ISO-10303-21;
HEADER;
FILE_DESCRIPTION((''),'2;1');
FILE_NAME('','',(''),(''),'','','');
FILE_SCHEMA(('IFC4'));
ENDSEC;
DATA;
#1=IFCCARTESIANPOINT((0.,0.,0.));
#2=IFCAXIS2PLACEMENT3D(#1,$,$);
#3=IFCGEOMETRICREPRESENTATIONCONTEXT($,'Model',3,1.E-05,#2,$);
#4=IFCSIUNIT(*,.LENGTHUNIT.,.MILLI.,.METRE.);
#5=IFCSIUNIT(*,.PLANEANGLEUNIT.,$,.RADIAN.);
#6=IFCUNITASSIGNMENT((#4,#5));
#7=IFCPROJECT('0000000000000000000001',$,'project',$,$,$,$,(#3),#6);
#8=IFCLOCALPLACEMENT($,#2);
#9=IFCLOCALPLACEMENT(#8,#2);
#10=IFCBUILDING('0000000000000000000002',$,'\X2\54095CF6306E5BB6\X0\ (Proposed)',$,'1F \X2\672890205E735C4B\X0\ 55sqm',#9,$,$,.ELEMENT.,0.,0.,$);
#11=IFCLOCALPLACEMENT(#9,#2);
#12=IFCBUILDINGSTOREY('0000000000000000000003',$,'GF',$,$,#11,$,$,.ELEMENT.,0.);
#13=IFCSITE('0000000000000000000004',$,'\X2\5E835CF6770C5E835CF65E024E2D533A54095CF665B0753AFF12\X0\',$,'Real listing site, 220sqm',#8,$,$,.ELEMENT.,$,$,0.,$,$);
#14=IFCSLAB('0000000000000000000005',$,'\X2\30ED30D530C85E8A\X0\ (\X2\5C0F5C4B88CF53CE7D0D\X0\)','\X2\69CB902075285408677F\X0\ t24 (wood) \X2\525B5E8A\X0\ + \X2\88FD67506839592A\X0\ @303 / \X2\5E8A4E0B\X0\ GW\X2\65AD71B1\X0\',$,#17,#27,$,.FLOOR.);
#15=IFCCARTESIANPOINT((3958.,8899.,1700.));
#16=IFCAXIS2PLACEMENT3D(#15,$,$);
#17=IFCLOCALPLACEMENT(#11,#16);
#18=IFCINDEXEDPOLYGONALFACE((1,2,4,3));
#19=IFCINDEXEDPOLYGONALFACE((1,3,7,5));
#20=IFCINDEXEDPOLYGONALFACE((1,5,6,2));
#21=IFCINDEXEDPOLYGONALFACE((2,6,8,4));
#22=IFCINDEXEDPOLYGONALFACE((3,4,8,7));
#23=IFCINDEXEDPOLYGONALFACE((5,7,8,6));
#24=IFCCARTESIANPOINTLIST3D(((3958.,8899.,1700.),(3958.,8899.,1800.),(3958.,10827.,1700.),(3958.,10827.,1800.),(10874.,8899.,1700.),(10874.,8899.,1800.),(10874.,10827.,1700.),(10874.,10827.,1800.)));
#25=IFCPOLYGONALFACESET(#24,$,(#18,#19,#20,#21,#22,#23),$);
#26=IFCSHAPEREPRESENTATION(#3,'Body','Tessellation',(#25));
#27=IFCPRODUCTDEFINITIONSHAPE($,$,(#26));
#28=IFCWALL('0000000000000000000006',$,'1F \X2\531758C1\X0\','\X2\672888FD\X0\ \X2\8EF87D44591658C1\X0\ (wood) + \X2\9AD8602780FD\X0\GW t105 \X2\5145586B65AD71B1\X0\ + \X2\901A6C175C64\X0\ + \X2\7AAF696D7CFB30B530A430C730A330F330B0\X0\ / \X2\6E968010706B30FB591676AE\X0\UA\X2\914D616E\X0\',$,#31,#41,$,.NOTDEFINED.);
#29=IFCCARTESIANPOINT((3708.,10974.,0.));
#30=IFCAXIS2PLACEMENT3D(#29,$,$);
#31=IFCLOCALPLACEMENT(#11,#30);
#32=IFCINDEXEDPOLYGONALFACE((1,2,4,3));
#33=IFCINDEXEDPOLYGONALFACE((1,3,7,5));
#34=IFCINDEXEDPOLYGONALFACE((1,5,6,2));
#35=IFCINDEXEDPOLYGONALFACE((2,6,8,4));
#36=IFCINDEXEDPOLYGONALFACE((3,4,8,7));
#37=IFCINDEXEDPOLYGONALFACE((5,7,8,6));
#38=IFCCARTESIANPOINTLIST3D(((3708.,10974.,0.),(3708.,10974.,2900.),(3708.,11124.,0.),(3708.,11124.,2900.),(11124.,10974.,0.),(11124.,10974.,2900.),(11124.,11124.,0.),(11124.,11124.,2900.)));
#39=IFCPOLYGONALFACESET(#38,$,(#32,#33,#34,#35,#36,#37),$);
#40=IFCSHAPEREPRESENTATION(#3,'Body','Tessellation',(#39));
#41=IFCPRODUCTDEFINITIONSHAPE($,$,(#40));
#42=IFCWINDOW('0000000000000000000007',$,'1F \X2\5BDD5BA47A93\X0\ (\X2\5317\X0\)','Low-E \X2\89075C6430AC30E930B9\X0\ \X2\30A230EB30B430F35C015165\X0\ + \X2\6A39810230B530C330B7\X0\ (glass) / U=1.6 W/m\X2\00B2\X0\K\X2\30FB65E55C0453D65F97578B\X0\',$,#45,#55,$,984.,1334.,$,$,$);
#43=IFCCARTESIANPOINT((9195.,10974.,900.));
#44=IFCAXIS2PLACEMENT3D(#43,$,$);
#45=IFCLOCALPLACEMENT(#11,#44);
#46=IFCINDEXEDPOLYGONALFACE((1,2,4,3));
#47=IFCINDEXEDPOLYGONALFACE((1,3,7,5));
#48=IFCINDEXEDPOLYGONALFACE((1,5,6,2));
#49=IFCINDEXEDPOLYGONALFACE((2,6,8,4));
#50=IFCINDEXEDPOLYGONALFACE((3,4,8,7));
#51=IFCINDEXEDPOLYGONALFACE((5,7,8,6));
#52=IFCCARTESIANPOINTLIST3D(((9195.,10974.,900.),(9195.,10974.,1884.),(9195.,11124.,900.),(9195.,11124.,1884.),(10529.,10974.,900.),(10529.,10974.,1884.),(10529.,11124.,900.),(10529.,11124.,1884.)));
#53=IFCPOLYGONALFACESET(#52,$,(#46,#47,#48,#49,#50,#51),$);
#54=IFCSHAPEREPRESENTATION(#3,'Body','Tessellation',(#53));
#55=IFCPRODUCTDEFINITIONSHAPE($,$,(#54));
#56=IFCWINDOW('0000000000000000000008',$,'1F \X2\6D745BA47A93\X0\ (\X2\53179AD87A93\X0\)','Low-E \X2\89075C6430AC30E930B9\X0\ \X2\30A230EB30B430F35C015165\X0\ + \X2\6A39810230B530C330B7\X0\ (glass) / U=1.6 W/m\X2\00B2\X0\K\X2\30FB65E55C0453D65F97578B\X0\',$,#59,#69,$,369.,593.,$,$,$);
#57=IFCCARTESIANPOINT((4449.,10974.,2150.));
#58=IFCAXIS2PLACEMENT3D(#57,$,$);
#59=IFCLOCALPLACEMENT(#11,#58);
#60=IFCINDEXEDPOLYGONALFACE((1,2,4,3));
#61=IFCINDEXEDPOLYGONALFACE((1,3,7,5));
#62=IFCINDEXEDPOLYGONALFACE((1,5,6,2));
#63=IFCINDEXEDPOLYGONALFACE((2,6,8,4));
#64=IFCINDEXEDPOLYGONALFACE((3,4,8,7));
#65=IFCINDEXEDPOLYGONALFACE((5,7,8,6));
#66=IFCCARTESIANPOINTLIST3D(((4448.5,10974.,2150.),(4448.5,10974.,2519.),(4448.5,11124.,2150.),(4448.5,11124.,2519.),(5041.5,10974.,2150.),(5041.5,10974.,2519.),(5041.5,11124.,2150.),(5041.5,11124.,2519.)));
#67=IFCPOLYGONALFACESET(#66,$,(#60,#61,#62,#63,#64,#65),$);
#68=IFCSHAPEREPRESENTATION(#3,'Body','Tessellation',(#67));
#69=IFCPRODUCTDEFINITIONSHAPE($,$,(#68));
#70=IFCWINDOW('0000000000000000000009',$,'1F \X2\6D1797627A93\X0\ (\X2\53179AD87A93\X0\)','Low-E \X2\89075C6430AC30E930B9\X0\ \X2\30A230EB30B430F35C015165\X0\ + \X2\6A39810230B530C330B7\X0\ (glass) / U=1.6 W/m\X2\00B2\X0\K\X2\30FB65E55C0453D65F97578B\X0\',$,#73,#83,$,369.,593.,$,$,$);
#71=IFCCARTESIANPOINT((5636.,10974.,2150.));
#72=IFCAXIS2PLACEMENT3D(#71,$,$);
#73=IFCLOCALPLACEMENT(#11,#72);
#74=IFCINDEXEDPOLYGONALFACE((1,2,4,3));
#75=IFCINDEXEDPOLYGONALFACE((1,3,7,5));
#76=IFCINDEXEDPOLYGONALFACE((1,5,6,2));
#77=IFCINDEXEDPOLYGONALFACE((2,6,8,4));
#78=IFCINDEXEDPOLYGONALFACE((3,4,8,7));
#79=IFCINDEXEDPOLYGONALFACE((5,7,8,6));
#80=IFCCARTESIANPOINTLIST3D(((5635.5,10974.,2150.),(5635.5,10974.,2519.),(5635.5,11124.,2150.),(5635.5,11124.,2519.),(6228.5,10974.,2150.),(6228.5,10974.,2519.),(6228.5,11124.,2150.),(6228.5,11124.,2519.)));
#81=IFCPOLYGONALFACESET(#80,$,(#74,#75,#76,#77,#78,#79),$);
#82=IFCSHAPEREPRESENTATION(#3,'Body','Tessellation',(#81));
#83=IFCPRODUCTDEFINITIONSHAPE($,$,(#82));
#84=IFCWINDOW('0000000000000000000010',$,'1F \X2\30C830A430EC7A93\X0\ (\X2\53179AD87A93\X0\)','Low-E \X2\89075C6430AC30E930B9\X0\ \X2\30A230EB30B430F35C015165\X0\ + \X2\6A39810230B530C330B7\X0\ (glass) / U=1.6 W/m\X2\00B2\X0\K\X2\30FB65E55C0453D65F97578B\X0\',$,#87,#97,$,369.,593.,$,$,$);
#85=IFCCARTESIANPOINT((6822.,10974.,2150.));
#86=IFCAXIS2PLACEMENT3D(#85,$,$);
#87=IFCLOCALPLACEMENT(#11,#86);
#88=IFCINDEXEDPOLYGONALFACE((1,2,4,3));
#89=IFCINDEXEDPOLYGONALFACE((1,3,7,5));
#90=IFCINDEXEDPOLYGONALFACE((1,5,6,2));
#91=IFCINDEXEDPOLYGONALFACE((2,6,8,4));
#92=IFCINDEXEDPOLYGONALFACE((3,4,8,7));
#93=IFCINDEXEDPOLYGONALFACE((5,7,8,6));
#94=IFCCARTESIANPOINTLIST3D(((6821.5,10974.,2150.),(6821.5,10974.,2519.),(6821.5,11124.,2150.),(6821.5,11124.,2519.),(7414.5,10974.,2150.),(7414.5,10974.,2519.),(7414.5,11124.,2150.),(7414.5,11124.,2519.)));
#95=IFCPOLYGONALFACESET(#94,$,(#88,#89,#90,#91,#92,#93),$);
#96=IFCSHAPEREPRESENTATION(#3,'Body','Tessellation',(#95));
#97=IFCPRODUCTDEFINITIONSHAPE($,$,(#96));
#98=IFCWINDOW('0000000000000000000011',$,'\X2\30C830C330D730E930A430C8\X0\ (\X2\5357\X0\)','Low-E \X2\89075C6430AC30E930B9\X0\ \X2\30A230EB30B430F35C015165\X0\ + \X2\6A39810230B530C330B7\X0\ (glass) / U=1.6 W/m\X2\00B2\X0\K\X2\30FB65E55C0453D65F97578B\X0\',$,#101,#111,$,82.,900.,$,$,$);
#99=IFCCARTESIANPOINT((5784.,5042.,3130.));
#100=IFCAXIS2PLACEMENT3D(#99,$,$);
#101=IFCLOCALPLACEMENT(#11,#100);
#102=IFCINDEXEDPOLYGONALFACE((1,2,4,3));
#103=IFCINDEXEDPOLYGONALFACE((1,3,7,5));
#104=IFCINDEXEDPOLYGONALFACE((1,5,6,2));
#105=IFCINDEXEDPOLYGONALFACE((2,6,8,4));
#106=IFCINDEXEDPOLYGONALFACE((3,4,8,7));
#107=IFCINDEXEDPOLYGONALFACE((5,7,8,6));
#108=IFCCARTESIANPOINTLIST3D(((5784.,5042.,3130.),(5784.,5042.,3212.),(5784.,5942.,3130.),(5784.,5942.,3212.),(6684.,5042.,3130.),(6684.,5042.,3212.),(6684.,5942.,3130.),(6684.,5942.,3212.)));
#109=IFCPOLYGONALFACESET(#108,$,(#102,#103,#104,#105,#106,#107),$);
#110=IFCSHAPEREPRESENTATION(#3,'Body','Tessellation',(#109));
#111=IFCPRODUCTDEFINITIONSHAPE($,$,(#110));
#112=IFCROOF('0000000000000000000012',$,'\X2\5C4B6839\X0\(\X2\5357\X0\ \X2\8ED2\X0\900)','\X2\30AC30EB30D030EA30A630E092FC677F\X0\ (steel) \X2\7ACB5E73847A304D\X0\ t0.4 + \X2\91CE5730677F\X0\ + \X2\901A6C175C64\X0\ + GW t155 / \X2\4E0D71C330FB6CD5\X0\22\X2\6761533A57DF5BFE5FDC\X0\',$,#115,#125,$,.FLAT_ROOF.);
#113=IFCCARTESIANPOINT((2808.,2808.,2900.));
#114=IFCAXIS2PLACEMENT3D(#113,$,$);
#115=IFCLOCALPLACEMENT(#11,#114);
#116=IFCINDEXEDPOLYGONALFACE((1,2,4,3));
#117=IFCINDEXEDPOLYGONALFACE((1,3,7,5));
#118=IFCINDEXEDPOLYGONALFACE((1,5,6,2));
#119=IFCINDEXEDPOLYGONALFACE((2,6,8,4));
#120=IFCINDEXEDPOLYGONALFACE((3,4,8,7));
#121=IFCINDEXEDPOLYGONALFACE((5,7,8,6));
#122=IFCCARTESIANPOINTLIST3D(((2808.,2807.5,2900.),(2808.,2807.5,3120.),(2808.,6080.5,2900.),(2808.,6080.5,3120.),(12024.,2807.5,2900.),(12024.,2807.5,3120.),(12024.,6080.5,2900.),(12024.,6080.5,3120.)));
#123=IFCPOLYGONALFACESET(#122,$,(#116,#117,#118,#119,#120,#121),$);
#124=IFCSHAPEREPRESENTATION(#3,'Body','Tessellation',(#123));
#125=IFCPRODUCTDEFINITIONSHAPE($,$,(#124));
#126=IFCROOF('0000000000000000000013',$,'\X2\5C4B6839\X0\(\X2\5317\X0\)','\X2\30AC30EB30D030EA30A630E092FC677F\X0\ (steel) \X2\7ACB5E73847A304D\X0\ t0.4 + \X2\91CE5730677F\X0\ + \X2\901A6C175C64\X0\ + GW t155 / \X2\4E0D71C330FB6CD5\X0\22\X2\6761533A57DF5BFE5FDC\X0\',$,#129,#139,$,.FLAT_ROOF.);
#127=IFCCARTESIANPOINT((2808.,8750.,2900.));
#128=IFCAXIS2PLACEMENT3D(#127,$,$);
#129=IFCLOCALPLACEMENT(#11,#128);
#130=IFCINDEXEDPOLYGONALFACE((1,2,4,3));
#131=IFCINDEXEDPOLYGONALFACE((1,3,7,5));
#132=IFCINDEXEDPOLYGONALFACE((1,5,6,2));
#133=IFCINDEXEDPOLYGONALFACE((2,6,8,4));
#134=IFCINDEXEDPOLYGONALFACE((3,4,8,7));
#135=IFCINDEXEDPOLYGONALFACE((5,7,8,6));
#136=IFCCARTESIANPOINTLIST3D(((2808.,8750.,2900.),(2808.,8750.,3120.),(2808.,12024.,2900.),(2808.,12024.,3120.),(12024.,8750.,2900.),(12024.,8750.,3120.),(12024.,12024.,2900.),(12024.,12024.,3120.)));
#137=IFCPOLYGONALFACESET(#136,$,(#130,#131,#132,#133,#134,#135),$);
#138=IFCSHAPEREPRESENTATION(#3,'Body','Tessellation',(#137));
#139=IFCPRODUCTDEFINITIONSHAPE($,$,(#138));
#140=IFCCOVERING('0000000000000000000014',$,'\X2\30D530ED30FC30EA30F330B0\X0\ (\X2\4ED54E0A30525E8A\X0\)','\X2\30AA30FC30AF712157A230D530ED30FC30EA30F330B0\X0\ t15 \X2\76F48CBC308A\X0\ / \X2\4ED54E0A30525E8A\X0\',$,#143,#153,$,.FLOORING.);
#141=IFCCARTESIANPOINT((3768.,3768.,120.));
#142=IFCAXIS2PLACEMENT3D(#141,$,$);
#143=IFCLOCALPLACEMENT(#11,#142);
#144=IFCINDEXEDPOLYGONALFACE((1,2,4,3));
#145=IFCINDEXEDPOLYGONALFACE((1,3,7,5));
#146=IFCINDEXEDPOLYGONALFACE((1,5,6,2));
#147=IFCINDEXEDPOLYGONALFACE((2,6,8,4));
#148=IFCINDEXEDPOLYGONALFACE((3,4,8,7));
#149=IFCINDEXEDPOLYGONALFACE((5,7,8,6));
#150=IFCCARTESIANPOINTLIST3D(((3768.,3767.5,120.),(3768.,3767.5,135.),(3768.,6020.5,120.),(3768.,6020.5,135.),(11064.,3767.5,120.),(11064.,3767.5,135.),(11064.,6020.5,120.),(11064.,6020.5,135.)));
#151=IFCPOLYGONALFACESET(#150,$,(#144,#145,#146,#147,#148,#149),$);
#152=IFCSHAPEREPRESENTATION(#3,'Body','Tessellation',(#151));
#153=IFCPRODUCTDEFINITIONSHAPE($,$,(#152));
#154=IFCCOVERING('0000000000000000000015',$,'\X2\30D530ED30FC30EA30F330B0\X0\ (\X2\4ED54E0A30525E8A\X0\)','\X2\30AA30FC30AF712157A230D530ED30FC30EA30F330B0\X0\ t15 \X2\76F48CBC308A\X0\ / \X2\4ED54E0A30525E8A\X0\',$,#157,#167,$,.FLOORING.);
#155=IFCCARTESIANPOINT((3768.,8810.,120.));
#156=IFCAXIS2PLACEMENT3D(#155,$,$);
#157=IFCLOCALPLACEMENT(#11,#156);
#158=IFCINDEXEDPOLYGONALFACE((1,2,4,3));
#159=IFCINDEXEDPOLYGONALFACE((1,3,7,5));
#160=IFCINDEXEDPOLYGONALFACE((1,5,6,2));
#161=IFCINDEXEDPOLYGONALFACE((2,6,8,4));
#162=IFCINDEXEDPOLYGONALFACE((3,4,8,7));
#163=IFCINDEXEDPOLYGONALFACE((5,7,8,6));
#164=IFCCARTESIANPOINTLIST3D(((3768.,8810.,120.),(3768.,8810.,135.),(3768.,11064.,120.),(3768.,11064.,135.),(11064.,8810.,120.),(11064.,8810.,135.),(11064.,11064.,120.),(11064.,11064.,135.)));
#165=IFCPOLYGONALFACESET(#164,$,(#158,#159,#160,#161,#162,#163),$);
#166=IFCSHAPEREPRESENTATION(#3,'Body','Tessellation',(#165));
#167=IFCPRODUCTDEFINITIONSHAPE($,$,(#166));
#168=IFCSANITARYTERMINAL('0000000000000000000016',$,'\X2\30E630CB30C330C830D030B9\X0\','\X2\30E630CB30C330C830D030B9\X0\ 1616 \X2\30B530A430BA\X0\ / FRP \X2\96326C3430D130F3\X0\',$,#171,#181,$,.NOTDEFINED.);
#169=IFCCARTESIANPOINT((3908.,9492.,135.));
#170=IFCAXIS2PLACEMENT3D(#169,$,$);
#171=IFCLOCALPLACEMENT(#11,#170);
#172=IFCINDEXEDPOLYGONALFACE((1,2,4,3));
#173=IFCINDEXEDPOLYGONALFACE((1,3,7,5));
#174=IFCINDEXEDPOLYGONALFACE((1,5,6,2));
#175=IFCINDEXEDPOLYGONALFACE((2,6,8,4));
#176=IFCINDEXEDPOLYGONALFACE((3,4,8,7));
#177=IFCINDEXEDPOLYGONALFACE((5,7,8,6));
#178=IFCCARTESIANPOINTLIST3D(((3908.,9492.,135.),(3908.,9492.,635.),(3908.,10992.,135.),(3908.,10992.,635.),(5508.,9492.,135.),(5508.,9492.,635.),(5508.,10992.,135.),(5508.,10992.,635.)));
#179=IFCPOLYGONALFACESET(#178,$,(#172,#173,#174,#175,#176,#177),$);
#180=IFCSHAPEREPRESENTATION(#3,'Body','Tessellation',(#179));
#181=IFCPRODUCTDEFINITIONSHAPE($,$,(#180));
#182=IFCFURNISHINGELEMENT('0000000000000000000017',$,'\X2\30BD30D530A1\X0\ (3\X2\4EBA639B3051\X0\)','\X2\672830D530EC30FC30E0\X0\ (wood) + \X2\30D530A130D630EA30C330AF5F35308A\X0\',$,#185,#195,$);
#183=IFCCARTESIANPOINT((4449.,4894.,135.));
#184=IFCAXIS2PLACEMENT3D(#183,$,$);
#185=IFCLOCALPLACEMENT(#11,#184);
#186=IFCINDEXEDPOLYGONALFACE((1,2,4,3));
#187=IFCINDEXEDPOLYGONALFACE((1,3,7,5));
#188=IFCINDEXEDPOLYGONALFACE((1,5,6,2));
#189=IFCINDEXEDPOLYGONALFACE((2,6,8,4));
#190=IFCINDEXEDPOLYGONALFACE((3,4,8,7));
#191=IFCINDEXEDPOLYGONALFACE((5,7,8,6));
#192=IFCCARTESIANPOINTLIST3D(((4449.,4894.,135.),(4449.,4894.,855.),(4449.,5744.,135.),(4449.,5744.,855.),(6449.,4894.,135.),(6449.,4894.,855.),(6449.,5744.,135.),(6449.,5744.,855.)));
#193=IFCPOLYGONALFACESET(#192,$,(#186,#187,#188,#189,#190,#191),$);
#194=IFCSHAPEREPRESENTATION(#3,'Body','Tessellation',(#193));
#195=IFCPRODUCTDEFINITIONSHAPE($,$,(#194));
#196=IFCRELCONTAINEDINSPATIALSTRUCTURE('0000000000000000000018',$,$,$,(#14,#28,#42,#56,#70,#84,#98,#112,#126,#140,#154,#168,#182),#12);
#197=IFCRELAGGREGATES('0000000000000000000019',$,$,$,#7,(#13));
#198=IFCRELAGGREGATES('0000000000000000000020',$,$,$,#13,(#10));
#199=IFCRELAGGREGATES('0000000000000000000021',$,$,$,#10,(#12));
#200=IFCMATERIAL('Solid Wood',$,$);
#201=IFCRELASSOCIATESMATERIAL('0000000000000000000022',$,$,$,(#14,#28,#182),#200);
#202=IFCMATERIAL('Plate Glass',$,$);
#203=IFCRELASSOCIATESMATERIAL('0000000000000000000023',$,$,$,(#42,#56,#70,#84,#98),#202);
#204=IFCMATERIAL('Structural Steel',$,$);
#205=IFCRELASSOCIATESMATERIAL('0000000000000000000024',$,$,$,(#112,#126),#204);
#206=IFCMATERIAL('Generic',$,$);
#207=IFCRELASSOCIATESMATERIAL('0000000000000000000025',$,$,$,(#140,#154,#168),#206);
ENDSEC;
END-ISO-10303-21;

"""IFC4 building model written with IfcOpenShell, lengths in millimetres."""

from ifc_helpers import new_model, si_unit, frame, frame_2d, origin, place, context, project, spatial, rectangle, extrude, material, element, fill, save


model = new_model("IFC4")

# Units and contexts
model_context = context("Model", 3, precision=1e-05, world=origin())
ifc_project = project(units=[si_unit("LENGTHUNIT", "METRE", prefix="MILLI"), si_unit("PLANEANGLEUNIT", "RADIAN")], contexts=[model_context])

# Site, building, storey
site_placement = place(None, origin())
site = spatial("IfcSite", under=ifc_project, at=site_placement, Name="広島県広島市中区吉島新町２", ObjectType="Real listing site, 220sqm", CompositionType="ELEMENT", RefElevation=0.0)
building_placement = place(site_placement, origin())
building = spatial("IfcBuilding", under=site, at=building_placement, Name="吉島の家 (Proposed)", ObjectType="1F 木造平屋 55sqm", CompositionType="ELEMENT", ElevationOfRefHeight=0.0, ElevationOfTerrain=0.0)
storey_placement = place(building_placement, origin())
storey = spatial("IfcBuildingStorey", under=building, at=storey_placement, Name="GF", CompositionType="ELEMENT", Elevation=0.0)

# Slab
ifc_material_1 = material(Name="Solid Wood")
slab_1_placement = place(storey_placement, frame((3958.0, 8899.0, 1700.0)))
element("IfcSlab", 1, at=slab_1_placement, inside=storey, material=ifc_material_1, Name="ロフト床 (小屋裏収納)", Description="構造用合板 t24 (wood) 剛床 + 製材根太 @303 / 床下 GW断熱", PredefinedType="FLOOR", context=model_context, shape_type="SweptSolid", body=[
    extrude(rectangle(XDim=6916.0, YDim=1928.0, at=frame_2d((3458.0, 964.0))), frame((3958.0, 8899.0, 1700.0)), (0.0, 0.0, 1.0), 100.0),
])

# Shared definitions
ifc_material_2 = material(Name="Plate Glass")

# Wall, openings, windows
wall_1_placement = place(storey_placement, frame((3708.0, 10974.0, 0.0)))
wall_1 = element("IfcWall", 2, at=wall_1_placement, inside=storey, material=ifc_material_1, Name="1F 北壁", Description="木製 軸組外壁 (wood) + 高性能GW t105 充填断熱 + 通気層 + 窯業系サイディング / 準耐火・外皮UA配慮", PredefinedType="NOTDEFINED", context=model_context, shape_type="SweptSolid", body=[
    extrude(rectangle(XDim=7416.0, YDim=150.0, at=frame_2d((3708.0, 75.0))), frame((3708.0, 10974.0, 0.0)), (0.0, 0.0, 1.0), 2900.0),
])
opening_1_placement = place(storey_placement, frame((9195.0, 10974.0, 900.0)))
opening_1 = element("IfcOpeningElement", 3, at=opening_1_placement, cuts=wall_1, PredefinedType="NOTDEFINED", context=model_context, shape_type="SweptSolid", body=[
    extrude(rectangle(XDim=1334.0, YDim=150.0, at=frame_2d((667.0, 75.0))), frame((9195.0, 10974.0, 900.0)), (0.0, 0.0, 1.0), 984.0),
])
opening_2_placement = place(storey_placement, frame((4449.0, 10974.0, 2150.0)))
opening_2 = element("IfcOpeningElement", 4, at=opening_2_placement, cuts=wall_1, PredefinedType="NOTDEFINED", context=model_context, shape_type="SweptSolid", body=[
    extrude(rectangle(XDim=593.0, YDim=150.0, at=frame_2d((296.0, 75.0))), frame((4449.0, 10974.0, 2150.0)), (0.0, 0.0, 1.0), 369.0),
])
opening_3_placement = place(storey_placement, frame((5636.0, 10974.0, 2150.0)))
opening_3 = element("IfcOpeningElement", 5, at=opening_3_placement, cuts=wall_1, PredefinedType="NOTDEFINED", context=model_context, shape_type="SweptSolid", body=[
    extrude(rectangle(XDim=593.0, YDim=150.0, at=frame_2d((296.0, 75.0))), frame((5636.0, 10974.0, 2150.0)), (0.0, 0.0, 1.0), 369.0),
])
opening_4_placement = place(storey_placement, frame((6822.0, 10974.0, 2150.0)))
opening_4 = element("IfcOpeningElement", 6, at=opening_4_placement, cuts=wall_1, PredefinedType="NOTDEFINED", context=model_context, shape_type="SweptSolid", body=[
    extrude(rectangle(XDim=593.0, YDim=150.0, at=frame_2d((296.0, 75.0))), frame((6822.0, 10974.0, 2150.0)), (0.0, 0.0, 1.0), 369.0),
])
window_1_placement = place(storey_placement, frame((9195.0, 10974.0, 900.0)))
window_1 = element("IfcWindow", 7, at=window_1_placement, inside=storey, material=ifc_material_2, Name="1F 寝室窓 (北)", Description="Low-E 複層ガラス アルゴン封入 + 樹脂サッシ (glass) / U=1.6 W/m²K・日射取得型", OverallHeight=984.0, OverallWidth=1334.0, context=model_context, shape_type="SweptSolid", body=[
    extrude(rectangle(XDim=1334.0, YDim=150.0, at=frame_2d((667.0, 75.0))), frame((9195.0, 10974.0, 900.0)), (0.0, 0.0, 1.0), 984.0),
])
fill(opening_1, window_1)
window_2_placement = place(storey_placement, frame((4449.0, 10974.0, 2150.0)))
window_2 = element("IfcWindow", 8, at=window_2_placement, inside=storey, material=ifc_material_2, Name="1F 浴室窓 (北高窓)", Description="Low-E 複層ガラス アルゴン封入 + 樹脂サッシ (glass) / U=1.6 W/m²K・日射取得型", OverallHeight=369.0, OverallWidth=593.0, context=model_context, shape_type="SweptSolid", body=[
    extrude(rectangle(XDim=593.0, YDim=150.0, at=frame_2d((296.0, 75.0))), frame((4449.0, 10974.0, 2150.0)), (0.0, 0.0, 1.0), 369.0),
])
fill(opening_2, window_2)
window_3_placement = place(storey_placement, frame((5636.0, 10974.0, 2150.0)))
window_3 = element("IfcWindow", 9, at=window_3_placement, inside=storey, material=ifc_material_2, Name="1F 洗面窓 (北高窓)", Description="Low-E 複層ガラス アルゴン封入 + 樹脂サッシ (glass) / U=1.6 W/m²K・日射取得型", OverallHeight=369.0, OverallWidth=593.0, context=model_context, shape_type="SweptSolid", body=[
    extrude(rectangle(XDim=593.0, YDim=150.0, at=frame_2d((296.0, 75.0))), frame((5636.0, 10974.0, 2150.0)), (0.0, 0.0, 1.0), 369.0),
])
fill(opening_3, window_3)
window_4_placement = place(storey_placement, frame((6822.0, 10974.0, 2150.0)))
window_4 = element("IfcWindow", 10, at=window_4_placement, inside=storey, material=ifc_material_2, Name="1F トイレ窓 (北高窓)", Description="Low-E 複層ガラス アルゴン封入 + 樹脂サッシ (glass) / U=1.6 W/m²K・日射取得型", OverallHeight=369.0, OverallWidth=593.0, context=model_context, shape_type="SweptSolid", body=[
    extrude(rectangle(XDim=593.0, YDim=150.0, at=frame_2d((296.0, 75.0))), frame((6822.0, 10974.0, 2150.0)), (0.0, 0.0, 1.0), 369.0),
])
fill(opening_4, window_4)

# Window
window_5_placement = place(storey_placement, frame((5784.0, 5042.0, 3130.0)))
element("IfcWindow", 11, at=window_5_placement, inside=storey, material=ifc_material_2, Name="トップライト (南)", Description="Low-E 複層ガラス アルゴン封入 + 樹脂サッシ (glass) / U=1.6 W/m²K・日射取得型", OverallHeight=82.0, OverallWidth=900.0, context=model_context, shape_type="SweptSolid", body=[
    extrude(rectangle(XDim=900.0, YDim=900.0, at=frame_2d((450.0, 450.0))), frame((5784.0, 5042.0, 3130.0)), (0.0, 0.0, 1.0), 82.0),
])

# Roofs
ifc_material_3 = material(Name="Structural Steel")
roof_1_placement = place(storey_placement, frame((2808.0, 2808.0, 2900.0)))
element("IfcRoof", 12, at=roof_1_placement, inside=storey, material=ifc_material_3, Name="屋根(南 軒900)", Description="ガルバリウム鋼板 (steel) 立平葺き t0.4 + 野地板 + 通気層 + GW t155 / 不燃・法22条区域対応", PredefinedType="FLAT_ROOF", context=model_context, shape_type="SweptSolid", body=[
    extrude(rectangle(XDim=9216.0, YDim=3273.0, at=frame_2d((4608.0, 1636.0))), frame((2808.0, 2808.0, 2900.0)), (0.0, 0.0, 1.0), 220.0),
])
roof_2_placement = place(storey_placement, frame((2808.0, 8750.0, 2900.0)))
element("IfcRoof", 13, at=roof_2_placement, inside=storey, material=ifc_material_3, Name="屋根(北)", Description="ガルバリウム鋼板 (steel) 立平葺き t0.4 + 野地板 + 通気層 + GW t155 / 不燃・法22条区域対応", PredefinedType="FLAT_ROOF", context=model_context, shape_type="SweptSolid", body=[
    extrude(rectangle(XDim=9216.0, YDim=3274.0, at=frame_2d((4608.0, 1637.0))), frame((2808.0, 8750.0, 2900.0)), (0.0, 0.0, 1.0), 220.0),
])

# Coverings
ifc_material_4 = material(Name="Generic")
covering_1_placement = place(storey_placement, frame((3768.0, 3768.0, 120.0)))
element("IfcCovering", 14, at=covering_1_placement, inside=storey, material=ifc_material_4, Name="フローリング (仕上げ床)", Description="オーク無垢フローリング t15 直貼り / 仕上げ床", PredefinedType="FLOORING", context=model_context, shape_type="SweptSolid", body=[
    extrude(rectangle(XDim=7296.0, YDim=2253.0, at=frame_2d((3648.0, 1126.0))), frame((3768.0, 3768.0, 120.0)), (0.0, 0.0, 1.0), 15.0),
])
covering_2_placement = place(storey_placement, frame((3768.0, 8810.0, 120.0)))
element("IfcCovering", 15, at=covering_2_placement, inside=storey, material=ifc_material_4, Name="フローリング (仕上げ床)", Description="オーク無垢フローリング t15 直貼り / 仕上げ床", PredefinedType="FLOORING", context=model_context, shape_type="SweptSolid", body=[
    extrude(rectangle(XDim=7296.0, YDim=2254.0, at=frame_2d((3648.0, 1127.0))), frame((3768.0, 8810.0, 120.0)), (0.0, 0.0, 1.0), 15.0),
])

# Sanitary terminal
sanitary_terminal_placement = place(storey_placement, frame((3908.0, 9492.0, 135.0)))
element("IfcSanitaryTerminal", 16, at=sanitary_terminal_placement, inside=storey, material=ifc_material_4, Name="ユニットバス", Description="ユニットバス 1616 サイズ / FRP 防水パン", PredefinedType="NOTDEFINED", context=model_context, shape_type="SweptSolid", body=[
    extrude(rectangle(XDim=1600.0, YDim=1500.0, at=frame_2d((800.0, 750.0))), frame((3908.0, 9492.0, 135.0)), (0.0, 0.0, 1.0), 500.0),
])

# Furnishing element
furnishing_1_placement = place(storey_placement, frame((4449.0, 4894.0, 135.0)))
element("IfcFurnishingElement", 17, at=furnishing_1_placement, inside=storey, material=ifc_material_1, Name="ソファ (3人掛け)", Description="木フレーム (wood) + ファブリック張り", context=model_context, shape_type="SweptSolid", body=[
    extrude(rectangle(XDim=2000.0, YDim=850.0, at=frame_2d((1000.0, 425.0))), frame((4449.0, 4894.0, 135.0)), (0.0, 0.0, 1.0), 720.0),
])

save(model, "model.ifc")
